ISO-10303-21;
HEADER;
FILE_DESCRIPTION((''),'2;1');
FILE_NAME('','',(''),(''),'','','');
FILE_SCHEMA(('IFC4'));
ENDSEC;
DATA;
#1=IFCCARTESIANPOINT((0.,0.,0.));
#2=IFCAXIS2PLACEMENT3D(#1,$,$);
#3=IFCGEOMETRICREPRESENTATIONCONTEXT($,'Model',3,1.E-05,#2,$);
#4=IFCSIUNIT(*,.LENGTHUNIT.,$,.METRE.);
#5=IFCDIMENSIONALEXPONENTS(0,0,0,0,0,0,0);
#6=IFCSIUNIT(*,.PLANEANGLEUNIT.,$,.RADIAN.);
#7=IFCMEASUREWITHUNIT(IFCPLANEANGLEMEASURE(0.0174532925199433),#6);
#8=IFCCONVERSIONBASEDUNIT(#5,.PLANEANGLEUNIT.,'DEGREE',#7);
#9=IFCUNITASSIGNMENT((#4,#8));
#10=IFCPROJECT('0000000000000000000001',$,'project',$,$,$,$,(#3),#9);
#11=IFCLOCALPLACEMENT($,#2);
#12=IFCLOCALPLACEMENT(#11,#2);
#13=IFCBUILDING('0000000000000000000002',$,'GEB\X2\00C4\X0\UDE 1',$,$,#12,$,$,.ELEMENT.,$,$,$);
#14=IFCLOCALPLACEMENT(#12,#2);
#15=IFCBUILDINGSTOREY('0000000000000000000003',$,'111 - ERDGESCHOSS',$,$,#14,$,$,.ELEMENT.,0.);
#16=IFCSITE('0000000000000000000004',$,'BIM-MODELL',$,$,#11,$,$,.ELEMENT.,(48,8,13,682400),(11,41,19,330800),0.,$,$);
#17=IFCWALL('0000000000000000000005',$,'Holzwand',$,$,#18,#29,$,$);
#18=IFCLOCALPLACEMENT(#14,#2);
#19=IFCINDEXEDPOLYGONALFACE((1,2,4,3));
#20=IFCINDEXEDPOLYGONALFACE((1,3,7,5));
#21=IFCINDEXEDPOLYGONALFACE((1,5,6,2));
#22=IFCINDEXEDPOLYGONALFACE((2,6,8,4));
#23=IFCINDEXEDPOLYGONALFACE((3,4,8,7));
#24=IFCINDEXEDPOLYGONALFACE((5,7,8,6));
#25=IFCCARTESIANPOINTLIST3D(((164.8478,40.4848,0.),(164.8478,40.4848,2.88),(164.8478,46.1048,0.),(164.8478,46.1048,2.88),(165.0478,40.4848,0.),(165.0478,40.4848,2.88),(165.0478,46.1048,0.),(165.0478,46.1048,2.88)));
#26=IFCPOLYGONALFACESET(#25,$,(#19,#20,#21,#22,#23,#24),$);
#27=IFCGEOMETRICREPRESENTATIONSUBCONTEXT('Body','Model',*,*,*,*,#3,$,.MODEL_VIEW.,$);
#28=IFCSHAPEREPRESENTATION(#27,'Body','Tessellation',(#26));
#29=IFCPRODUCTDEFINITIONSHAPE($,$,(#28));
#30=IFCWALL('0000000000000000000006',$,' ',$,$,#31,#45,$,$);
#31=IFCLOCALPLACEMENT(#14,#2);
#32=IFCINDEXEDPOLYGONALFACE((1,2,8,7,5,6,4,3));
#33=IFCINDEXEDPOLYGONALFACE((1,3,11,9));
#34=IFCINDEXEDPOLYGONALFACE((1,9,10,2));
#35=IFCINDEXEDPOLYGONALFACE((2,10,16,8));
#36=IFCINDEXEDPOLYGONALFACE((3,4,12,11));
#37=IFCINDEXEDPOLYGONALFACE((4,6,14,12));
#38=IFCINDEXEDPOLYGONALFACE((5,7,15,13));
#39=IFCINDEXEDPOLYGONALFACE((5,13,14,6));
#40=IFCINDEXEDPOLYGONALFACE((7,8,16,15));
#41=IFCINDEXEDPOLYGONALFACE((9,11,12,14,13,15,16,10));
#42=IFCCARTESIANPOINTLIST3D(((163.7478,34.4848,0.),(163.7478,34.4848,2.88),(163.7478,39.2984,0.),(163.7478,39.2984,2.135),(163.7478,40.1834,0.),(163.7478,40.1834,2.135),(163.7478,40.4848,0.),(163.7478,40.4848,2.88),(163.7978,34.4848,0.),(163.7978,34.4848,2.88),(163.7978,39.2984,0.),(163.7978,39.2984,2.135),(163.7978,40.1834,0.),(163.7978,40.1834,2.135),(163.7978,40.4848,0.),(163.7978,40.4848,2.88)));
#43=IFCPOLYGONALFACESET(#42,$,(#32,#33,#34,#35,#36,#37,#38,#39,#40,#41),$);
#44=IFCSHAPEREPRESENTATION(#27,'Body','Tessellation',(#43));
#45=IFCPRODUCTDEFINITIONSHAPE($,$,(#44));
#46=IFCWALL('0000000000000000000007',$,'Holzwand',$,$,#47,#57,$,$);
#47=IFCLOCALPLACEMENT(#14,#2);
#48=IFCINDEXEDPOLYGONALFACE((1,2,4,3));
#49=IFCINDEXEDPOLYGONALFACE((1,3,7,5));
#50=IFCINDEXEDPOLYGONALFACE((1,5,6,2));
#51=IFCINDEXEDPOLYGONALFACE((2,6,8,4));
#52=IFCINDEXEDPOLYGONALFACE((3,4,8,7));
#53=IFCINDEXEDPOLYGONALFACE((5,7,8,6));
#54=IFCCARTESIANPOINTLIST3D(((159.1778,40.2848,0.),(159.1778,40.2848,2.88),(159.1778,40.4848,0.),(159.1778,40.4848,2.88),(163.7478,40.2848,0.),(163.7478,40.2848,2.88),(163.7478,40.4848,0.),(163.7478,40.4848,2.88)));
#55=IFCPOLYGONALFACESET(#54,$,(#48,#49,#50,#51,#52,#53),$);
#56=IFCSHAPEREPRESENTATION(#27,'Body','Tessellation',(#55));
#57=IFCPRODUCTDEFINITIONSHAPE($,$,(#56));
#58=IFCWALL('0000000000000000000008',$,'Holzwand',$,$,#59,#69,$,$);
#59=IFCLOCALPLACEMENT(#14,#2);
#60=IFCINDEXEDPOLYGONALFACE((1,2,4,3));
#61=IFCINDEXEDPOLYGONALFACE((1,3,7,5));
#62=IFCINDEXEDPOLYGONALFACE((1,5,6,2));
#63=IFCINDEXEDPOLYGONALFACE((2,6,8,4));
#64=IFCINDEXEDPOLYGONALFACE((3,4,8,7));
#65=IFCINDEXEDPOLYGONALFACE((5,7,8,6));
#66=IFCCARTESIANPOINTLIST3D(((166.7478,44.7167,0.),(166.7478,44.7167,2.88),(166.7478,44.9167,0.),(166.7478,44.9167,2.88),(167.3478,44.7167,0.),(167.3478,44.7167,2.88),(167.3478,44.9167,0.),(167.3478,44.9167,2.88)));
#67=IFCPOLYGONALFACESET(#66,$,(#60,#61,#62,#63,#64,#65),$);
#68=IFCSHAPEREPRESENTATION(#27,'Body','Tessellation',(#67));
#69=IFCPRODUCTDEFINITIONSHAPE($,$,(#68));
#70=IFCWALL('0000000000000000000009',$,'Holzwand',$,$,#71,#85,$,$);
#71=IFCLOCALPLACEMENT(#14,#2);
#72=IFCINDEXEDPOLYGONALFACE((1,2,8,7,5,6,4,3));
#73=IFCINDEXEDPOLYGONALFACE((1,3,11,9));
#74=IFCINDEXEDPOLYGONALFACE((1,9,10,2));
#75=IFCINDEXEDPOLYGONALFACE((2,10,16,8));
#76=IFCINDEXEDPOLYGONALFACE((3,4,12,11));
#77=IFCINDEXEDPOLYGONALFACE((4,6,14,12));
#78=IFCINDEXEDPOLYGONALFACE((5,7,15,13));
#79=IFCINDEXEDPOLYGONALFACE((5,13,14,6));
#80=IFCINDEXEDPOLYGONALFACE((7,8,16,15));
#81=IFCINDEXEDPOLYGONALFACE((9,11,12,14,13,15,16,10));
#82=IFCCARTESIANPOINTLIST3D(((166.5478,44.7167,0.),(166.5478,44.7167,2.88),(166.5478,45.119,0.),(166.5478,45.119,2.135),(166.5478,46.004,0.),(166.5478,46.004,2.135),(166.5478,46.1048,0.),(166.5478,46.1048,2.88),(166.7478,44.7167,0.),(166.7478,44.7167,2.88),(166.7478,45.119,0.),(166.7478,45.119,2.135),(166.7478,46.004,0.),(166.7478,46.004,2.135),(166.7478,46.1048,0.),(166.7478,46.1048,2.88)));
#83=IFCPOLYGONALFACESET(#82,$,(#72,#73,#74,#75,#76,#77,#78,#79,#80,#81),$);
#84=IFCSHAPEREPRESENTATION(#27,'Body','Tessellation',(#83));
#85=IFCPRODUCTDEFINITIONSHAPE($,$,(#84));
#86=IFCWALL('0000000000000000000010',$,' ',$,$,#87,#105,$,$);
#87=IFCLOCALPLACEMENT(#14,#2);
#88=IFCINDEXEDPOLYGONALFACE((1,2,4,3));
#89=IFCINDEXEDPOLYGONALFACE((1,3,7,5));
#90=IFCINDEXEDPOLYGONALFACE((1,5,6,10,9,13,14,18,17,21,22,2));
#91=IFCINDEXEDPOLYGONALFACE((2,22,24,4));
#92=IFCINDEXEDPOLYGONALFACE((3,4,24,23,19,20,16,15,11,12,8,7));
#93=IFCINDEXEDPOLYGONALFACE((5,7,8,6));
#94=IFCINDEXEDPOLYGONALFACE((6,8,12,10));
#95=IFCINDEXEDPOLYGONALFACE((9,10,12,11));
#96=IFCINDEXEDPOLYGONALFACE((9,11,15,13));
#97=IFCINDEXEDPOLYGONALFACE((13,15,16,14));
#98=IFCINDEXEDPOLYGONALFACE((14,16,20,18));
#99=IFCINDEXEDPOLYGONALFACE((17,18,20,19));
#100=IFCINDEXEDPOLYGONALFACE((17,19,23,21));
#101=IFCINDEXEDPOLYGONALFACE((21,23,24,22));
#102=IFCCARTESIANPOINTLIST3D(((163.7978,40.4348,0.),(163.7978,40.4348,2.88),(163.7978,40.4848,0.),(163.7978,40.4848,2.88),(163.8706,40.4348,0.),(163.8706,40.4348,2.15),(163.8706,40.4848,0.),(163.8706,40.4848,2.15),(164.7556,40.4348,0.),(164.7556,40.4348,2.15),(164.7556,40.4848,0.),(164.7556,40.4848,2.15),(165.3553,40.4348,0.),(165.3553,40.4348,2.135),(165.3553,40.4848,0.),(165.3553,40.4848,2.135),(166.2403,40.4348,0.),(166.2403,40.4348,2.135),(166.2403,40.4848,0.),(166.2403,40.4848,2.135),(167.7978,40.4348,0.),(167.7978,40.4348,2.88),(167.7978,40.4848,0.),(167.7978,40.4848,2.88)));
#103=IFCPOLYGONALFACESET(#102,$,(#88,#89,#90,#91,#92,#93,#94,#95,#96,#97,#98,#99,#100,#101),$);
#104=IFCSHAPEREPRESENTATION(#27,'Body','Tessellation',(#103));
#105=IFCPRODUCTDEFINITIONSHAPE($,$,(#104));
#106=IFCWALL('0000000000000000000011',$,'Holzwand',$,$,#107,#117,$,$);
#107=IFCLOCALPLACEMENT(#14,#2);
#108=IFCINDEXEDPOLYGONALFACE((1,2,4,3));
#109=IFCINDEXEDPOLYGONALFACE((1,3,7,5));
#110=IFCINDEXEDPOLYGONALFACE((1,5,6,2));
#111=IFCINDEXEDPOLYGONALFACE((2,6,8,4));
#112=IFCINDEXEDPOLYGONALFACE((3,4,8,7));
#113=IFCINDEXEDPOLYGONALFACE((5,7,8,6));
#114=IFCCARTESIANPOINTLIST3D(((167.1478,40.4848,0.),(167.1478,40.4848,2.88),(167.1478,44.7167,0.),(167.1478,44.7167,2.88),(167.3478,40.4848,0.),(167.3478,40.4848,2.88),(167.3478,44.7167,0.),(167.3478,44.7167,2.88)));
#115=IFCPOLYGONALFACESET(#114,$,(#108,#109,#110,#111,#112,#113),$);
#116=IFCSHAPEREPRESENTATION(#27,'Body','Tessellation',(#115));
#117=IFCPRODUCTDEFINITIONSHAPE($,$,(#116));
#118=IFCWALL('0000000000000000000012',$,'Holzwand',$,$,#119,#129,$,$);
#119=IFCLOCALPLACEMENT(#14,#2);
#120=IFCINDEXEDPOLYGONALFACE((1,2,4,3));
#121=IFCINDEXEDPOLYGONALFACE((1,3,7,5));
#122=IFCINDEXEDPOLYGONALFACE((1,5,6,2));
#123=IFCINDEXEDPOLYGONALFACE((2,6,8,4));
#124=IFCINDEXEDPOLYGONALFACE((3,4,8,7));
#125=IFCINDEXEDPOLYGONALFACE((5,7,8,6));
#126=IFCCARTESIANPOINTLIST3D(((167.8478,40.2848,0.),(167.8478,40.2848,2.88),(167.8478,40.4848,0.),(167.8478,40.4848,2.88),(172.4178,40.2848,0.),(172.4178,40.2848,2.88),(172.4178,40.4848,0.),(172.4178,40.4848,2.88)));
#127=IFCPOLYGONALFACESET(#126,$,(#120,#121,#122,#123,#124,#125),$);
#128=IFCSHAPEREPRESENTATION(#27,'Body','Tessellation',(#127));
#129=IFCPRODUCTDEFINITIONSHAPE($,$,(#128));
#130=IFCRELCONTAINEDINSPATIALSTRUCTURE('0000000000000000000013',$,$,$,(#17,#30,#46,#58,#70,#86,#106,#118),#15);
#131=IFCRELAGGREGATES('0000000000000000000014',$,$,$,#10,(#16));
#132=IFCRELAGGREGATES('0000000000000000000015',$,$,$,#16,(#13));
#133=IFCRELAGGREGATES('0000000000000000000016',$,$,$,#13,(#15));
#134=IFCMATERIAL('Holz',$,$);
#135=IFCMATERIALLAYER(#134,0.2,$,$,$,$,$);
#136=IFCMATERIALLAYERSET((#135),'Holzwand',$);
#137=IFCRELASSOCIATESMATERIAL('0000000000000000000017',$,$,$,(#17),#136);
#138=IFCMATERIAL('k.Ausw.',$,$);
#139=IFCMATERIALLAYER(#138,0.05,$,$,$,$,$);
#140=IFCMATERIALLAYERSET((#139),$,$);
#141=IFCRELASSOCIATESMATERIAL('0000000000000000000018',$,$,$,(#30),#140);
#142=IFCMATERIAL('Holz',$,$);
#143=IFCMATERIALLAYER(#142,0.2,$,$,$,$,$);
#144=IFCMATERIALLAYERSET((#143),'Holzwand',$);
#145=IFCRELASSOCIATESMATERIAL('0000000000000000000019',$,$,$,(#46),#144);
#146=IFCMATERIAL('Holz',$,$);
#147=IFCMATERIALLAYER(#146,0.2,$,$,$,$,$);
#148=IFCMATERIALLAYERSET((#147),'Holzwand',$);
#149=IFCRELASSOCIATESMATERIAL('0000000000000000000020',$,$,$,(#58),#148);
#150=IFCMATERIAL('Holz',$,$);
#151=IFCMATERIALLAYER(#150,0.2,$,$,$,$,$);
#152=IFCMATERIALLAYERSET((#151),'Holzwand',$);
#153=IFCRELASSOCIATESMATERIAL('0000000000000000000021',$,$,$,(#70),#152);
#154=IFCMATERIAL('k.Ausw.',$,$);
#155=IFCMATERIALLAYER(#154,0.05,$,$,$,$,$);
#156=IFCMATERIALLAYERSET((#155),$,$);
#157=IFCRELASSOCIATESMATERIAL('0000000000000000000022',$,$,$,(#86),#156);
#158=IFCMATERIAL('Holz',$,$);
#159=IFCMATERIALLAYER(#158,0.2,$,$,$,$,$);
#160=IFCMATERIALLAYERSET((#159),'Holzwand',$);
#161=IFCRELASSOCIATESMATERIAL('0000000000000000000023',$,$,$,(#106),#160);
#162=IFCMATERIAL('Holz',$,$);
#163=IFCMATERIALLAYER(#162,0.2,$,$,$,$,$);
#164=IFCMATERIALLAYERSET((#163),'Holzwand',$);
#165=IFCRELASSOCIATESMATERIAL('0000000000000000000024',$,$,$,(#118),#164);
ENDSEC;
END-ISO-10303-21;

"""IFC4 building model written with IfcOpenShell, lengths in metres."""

from ifc_helpers import new_model, entity, si_unit, converted_unit, frame, frame_2d, origin, origin_with_axes, place, context, subcontext, project, spatial, polyline, rectangle, outline, extrude, material, layer, layer_set, layer_usage, element, save


model = new_model("IFC4")

# Units and contexts
model_context = context("Model", 3, precision=1e-05, world=origin())
body_context = subcontext(model_context, "Body", "Model", "MODEL_VIEW")
ifc_project = project(units=[si_unit("LENGTHUNIT", "METRE"), converted_unit("PLANEANGLEUNIT", "DEGREE", entity("IfcPlaneAngleMeasure", 0.0174532925199433), si_unit("PLANEANGLEUNIT", "RADIAN"), dimensions=[0, 0, 0, 0, 0, 0, 0])], contexts=[model_context])

# Site, building, storey
site_placement = place(None, origin())
site = spatial("IfcSite", under=ifc_project, at=site_placement, Name="BIM-MODELL", CompositionType="ELEMENT", RefLatitude=(48, 8, 13, 682400), RefLongitude=(11, 41, 19, 330800), RefElevation=0.0)
building_placement = place(site_placement, origin())
building = spatial("IfcBuilding", under=site, at=building_placement, Name="GEBÄUDE 1", CompositionType="ELEMENT")
storey_placement = place(building_placement, origin())
storey = spatial("IfcBuildingStorey", under=building, at=storey_placement, Name="111 - ERDGESCHOSS", CompositionType="ELEMENT", Elevation=0.0)

# Wall
ifc_material_1 = material(Name="Holz")
ifc_layer_1 = layer(ifc_material_1, 0.2)
ifc_layer_set_1 = layer_set([ifc_layer_1], Name="Holzwand")
ifc_layer_usage_1 = layer_usage(ifc_layer_set_1, "AXIS2", "POSITIVE", 0.0)
wall_1_placement = place(storey_placement, frame((164.8478, 46.1048, 0.0), z_axis=(0.0, 0.0, 1.0), x_axis=(0.0, -1.0, 0.0)))
element("IfcWall", 1, at=wall_1_placement, inside=storey, material=ifc_layer_usage_1, Name="Holzwand", context=body_context, shape_type="SweptSolid", body=[
    extrude(rectangle(XDim=5.62, YDim=0.2, at=frame_2d((2.81, 0.1), x_axis=(1.0, 0.0))), origin_with_axes(), (0.0, 0.0, 1.0), 2.88),
])

# Wall, opening
ifc_material_2 = material(Name="k.Ausw.")
ifc_layer_2 = layer(ifc_material_2, 0.05)
ifc_layer_set_2 = layer_set([ifc_layer_2])
ifc_layer_usage_2 = layer_usage(ifc_layer_set_2, "AXIS2", "POSITIVE", 0.0)
wall_2_placement = place(storey_placement, frame((163.7478, 40.4848, 0.0), z_axis=(0.0, 0.0, 1.0), x_axis=(0.0, -1.0, 0.0)))
wall_2 = element("IfcWall", 2, at=wall_2_placement, inside=storey, material=ifc_layer_usage_2, Name=" ", context=body_context, shape_type="SweptSolid", body=[
    extrude(rectangle(XDim=6.0, YDim=0.05, at=frame_2d((3.0, 0.025), x_axis=(1.0, 0.0))), origin_with_axes(), (0.0, 0.0, 1.0), 2.88),
])
opening_1_placement = place(wall_2_placement, frame((0.3014, 0.0, 0.0), z_axis=(0.0, 1.0, 0.0), x_axis=(0.0, 0.0, 1.0)))
element("IfcOpeningElement", 3, at=opening_1_placement, cuts=wall_2, ObjectType="Opening", context=body_context, shape_type="SweptSolid", body=[
    extrude(outline(polyline([(0.0, 0.885), (2.135, 0.885), (2.135, 0.0), (0.0, 0.0), (0.0, 0.885)])), origin_with_axes(), (0.0, 0.0, 1.0), 0.05),
])

# Walls
ifc_material_3 = material(Name="Holz")
ifc_layer_3 = layer(ifc_material_3, 0.2)
ifc_layer_set_3 = layer_set([ifc_layer_3], Name="Holzwand")
ifc_layer_usage_3 = layer_usage(ifc_layer_set_3, "AXIS2", "POSITIVE", 0.0)
wall_3_placement = place(storey_placement, frame((163.7478, 40.4848, 0.0), z_axis=(0.0, 0.0, 1.0), x_axis=(-1.0, 0.0, 0.0)))
element("IfcWall", 4, at=wall_3_placement, inside=storey, material=ifc_layer_usage_3, Name="Holzwand", context=body_context, shape_type="SweptSolid", body=[
    extrude(rectangle(XDim=4.57, YDim=0.2, at=frame_2d((2.285, 0.1), x_axis=(1.0, 0.0))), origin_with_axes(), (0.0, 0.0, 1.0), 2.88),
])
ifc_material_4 = material(Name="Holz")
ifc_layer_4 = layer(ifc_material_4, 0.2)
ifc_layer_set_4 = layer_set([ifc_layer_4], Name="Holzwand")
ifc_layer_usage_4 = layer_usage(ifc_layer_set_4, "AXIS2", "POSITIVE", 0.0)
wall_4_placement = place(storey_placement, frame((166.7478, 44.7167, 0.0)))
element("IfcWall", 5, at=wall_4_placement, inside=storey, material=ifc_layer_usage_4, Name="Holzwand", context=body_context, shape_type="SweptSolid", body=[
    extrude(rectangle(XDim=0.6, YDim=0.2, at=frame_2d((0.3, 0.1), x_axis=(1.0, 0.0))), origin_with_axes(), (0.0, 0.0, 1.0), 2.88),
])

# Wall, opening
ifc_material_5 = material(Name="Holz")
ifc_layer_5 = layer(ifc_material_5, 0.2)
ifc_layer_set_5 = layer_set([ifc_layer_5], Name="Holzwand")
ifc_layer_usage_5 = layer_usage(ifc_layer_set_5, "AXIS2", "POSITIVE", 0.0)
wall_5_placement = place(storey_placement, frame((166.5478, 46.1048, 0.0), z_axis=(0.0, 0.0, 1.0), x_axis=(0.0, -1.0, 0.0)))
wall_5 = element("IfcWall", 6, at=wall_5_placement, inside=storey, material=ifc_layer_usage_5, Name="Holzwand", context=body_context, shape_type="SweptSolid", body=[
    extrude(rectangle(XDim=1.3881, YDim=0.2, at=frame_2d((0.6941, 0.1), x_axis=(1.0, 0.0))), origin_with_axes(), (0.0, 0.0, 1.0), 2.88),
])
opening_2_placement = place(wall_5_placement, frame((0.9858, 0.2, 0.0), z_axis=(0.0, -1.0, 0.0), x_axis=(0.0, 0.0, 1.0)))
element("IfcOpeningElement", 7, at=opening_2_placement, cuts=wall_5, ObjectType="Opening", context=body_context, shape_type="SweptSolid", body=[
    extrude(outline(polyline([(0.0, 0.885), (2.135, 0.885), (2.135, 0.0), (0.0, 0.0), (0.0, 0.885)])), origin_with_axes(), (0.0, 0.0, 1.0), 0.2),
])

# Wall, openings
ifc_material_6 = material(Name="k.Ausw.")
ifc_layer_6 = layer(ifc_material_6, 0.05)
ifc_layer_set_6 = layer_set([ifc_layer_6])
ifc_layer_usage_6 = layer_usage(ifc_layer_set_6, "AXIS2", "POSITIVE", 0.0)
wall_6_placement = place(storey_placement, frame((167.7978, 40.4848, 0.0), z_axis=(0.0, 0.0, 1.0), x_axis=(-1.0, 0.0, 0.0)))
wall_6 = element("IfcWall", 8, at=wall_6_placement, inside=storey, material=ifc_layer_usage_6, Name=" ", context=body_context, shape_type="SweptSolid", body=[
    extrude(rectangle(XDim=4.0, YDim=0.05, at=frame_2d((2.0, 0.025), x_axis=(1.0, 0.0))), origin_with_axes(), (0.0, 0.0, 1.0), 2.88),
])
opening_3_placement = place(wall_6_placement, frame((1.5575, 0.0, 0.0), z_axis=(0.0, 1.0, 0.0), x_axis=(0.0, 0.0, 1.0)))
element("IfcOpeningElement", 9, at=opening_3_placement, cuts=wall_6, ObjectType="Opening", context=body_context, shape_type="SweptSolid", body=[
    extrude(outline(polyline([(0.0, 0.885), (2.135, 0.885), (2.135, 0.0), (0.0, 0.0), (0.0, 0.885)])), origin_with_axes(), (0.0, 0.0, 1.0), 0.05),
])
opening_4_placement = place(wall_6_placement, frame((3.9272, 0.05, -0.15), z_axis=(0.0, -1.0, 0.0), x_axis=(0.0, 0.0, 1.0)))
element("IfcOpeningElement", 10, at=opening_4_placement, cuts=wall_6, ObjectType="Opening", context=body_context, shape_type="SweptSolid", body=[
    extrude(outline(polyline([(0.0, 0.885), (2.3, 0.885), (2.3, 0.0), (0.0, 0.0), (0.0, 0.885)])), origin_with_axes(), (0.0, 0.0, 1.0), 0.05),
])

# Walls
ifc_material_7 = material(Name="Holz")
ifc_layer_7 = layer(ifc_material_7, 0.2)
ifc_layer_set_7 = layer_set([ifc_layer_7], Name="Holzwand")
ifc_layer_usage_7 = layer_usage(ifc_layer_set_7, "AXIS2", "POSITIVE", 0.0)
wall_7_placement = place(storey_placement, frame((167.1478, 44.7167, 0.0), z_axis=(0.0, 0.0, 1.0), x_axis=(0.0, -1.0, 0.0)))
element("IfcWall", 11, at=wall_7_placement, inside=storey, material=ifc_layer_usage_7, Name="Holzwand", context=body_context, shape_type="SweptSolid", body=[
    extrude(rectangle(XDim=4.2319, YDim=0.2, at=frame_2d((2.1159, 0.1), x_axis=(1.0, 0.0))), origin_with_axes(), (0.0, 0.0, 1.0), 2.88),
])
ifc_material_8 = material(Name="Holz")
ifc_layer_8 = layer(ifc_material_8, 0.2)
ifc_layer_set_8 = layer_set([ifc_layer_8], Name="Holzwand")
ifc_layer_usage_8 = layer_usage(ifc_layer_set_8, "AXIS2", "POSITIVE", 0.0)
wall_8_placement = place(storey_placement, frame((172.4178, 40.4848, 0.0), z_axis=(0.0, 0.0, 1.0), x_axis=(-1.0, 0.0, 0.0)))
element("IfcWall", 12, at=wall_8_placement, inside=storey, material=ifc_layer_usage_8, Name="Holzwand", context=body_context, shape_type="SweptSolid", body=[
    extrude(rectangle(XDim=4.57, YDim=0.2, at=frame_2d((2.285, 0.1), x_axis=(1.0, 0.0))), origin_with_axes(), (0.0, 0.0, 1.0), 2.88),
])

save(model, "model.ifc")
